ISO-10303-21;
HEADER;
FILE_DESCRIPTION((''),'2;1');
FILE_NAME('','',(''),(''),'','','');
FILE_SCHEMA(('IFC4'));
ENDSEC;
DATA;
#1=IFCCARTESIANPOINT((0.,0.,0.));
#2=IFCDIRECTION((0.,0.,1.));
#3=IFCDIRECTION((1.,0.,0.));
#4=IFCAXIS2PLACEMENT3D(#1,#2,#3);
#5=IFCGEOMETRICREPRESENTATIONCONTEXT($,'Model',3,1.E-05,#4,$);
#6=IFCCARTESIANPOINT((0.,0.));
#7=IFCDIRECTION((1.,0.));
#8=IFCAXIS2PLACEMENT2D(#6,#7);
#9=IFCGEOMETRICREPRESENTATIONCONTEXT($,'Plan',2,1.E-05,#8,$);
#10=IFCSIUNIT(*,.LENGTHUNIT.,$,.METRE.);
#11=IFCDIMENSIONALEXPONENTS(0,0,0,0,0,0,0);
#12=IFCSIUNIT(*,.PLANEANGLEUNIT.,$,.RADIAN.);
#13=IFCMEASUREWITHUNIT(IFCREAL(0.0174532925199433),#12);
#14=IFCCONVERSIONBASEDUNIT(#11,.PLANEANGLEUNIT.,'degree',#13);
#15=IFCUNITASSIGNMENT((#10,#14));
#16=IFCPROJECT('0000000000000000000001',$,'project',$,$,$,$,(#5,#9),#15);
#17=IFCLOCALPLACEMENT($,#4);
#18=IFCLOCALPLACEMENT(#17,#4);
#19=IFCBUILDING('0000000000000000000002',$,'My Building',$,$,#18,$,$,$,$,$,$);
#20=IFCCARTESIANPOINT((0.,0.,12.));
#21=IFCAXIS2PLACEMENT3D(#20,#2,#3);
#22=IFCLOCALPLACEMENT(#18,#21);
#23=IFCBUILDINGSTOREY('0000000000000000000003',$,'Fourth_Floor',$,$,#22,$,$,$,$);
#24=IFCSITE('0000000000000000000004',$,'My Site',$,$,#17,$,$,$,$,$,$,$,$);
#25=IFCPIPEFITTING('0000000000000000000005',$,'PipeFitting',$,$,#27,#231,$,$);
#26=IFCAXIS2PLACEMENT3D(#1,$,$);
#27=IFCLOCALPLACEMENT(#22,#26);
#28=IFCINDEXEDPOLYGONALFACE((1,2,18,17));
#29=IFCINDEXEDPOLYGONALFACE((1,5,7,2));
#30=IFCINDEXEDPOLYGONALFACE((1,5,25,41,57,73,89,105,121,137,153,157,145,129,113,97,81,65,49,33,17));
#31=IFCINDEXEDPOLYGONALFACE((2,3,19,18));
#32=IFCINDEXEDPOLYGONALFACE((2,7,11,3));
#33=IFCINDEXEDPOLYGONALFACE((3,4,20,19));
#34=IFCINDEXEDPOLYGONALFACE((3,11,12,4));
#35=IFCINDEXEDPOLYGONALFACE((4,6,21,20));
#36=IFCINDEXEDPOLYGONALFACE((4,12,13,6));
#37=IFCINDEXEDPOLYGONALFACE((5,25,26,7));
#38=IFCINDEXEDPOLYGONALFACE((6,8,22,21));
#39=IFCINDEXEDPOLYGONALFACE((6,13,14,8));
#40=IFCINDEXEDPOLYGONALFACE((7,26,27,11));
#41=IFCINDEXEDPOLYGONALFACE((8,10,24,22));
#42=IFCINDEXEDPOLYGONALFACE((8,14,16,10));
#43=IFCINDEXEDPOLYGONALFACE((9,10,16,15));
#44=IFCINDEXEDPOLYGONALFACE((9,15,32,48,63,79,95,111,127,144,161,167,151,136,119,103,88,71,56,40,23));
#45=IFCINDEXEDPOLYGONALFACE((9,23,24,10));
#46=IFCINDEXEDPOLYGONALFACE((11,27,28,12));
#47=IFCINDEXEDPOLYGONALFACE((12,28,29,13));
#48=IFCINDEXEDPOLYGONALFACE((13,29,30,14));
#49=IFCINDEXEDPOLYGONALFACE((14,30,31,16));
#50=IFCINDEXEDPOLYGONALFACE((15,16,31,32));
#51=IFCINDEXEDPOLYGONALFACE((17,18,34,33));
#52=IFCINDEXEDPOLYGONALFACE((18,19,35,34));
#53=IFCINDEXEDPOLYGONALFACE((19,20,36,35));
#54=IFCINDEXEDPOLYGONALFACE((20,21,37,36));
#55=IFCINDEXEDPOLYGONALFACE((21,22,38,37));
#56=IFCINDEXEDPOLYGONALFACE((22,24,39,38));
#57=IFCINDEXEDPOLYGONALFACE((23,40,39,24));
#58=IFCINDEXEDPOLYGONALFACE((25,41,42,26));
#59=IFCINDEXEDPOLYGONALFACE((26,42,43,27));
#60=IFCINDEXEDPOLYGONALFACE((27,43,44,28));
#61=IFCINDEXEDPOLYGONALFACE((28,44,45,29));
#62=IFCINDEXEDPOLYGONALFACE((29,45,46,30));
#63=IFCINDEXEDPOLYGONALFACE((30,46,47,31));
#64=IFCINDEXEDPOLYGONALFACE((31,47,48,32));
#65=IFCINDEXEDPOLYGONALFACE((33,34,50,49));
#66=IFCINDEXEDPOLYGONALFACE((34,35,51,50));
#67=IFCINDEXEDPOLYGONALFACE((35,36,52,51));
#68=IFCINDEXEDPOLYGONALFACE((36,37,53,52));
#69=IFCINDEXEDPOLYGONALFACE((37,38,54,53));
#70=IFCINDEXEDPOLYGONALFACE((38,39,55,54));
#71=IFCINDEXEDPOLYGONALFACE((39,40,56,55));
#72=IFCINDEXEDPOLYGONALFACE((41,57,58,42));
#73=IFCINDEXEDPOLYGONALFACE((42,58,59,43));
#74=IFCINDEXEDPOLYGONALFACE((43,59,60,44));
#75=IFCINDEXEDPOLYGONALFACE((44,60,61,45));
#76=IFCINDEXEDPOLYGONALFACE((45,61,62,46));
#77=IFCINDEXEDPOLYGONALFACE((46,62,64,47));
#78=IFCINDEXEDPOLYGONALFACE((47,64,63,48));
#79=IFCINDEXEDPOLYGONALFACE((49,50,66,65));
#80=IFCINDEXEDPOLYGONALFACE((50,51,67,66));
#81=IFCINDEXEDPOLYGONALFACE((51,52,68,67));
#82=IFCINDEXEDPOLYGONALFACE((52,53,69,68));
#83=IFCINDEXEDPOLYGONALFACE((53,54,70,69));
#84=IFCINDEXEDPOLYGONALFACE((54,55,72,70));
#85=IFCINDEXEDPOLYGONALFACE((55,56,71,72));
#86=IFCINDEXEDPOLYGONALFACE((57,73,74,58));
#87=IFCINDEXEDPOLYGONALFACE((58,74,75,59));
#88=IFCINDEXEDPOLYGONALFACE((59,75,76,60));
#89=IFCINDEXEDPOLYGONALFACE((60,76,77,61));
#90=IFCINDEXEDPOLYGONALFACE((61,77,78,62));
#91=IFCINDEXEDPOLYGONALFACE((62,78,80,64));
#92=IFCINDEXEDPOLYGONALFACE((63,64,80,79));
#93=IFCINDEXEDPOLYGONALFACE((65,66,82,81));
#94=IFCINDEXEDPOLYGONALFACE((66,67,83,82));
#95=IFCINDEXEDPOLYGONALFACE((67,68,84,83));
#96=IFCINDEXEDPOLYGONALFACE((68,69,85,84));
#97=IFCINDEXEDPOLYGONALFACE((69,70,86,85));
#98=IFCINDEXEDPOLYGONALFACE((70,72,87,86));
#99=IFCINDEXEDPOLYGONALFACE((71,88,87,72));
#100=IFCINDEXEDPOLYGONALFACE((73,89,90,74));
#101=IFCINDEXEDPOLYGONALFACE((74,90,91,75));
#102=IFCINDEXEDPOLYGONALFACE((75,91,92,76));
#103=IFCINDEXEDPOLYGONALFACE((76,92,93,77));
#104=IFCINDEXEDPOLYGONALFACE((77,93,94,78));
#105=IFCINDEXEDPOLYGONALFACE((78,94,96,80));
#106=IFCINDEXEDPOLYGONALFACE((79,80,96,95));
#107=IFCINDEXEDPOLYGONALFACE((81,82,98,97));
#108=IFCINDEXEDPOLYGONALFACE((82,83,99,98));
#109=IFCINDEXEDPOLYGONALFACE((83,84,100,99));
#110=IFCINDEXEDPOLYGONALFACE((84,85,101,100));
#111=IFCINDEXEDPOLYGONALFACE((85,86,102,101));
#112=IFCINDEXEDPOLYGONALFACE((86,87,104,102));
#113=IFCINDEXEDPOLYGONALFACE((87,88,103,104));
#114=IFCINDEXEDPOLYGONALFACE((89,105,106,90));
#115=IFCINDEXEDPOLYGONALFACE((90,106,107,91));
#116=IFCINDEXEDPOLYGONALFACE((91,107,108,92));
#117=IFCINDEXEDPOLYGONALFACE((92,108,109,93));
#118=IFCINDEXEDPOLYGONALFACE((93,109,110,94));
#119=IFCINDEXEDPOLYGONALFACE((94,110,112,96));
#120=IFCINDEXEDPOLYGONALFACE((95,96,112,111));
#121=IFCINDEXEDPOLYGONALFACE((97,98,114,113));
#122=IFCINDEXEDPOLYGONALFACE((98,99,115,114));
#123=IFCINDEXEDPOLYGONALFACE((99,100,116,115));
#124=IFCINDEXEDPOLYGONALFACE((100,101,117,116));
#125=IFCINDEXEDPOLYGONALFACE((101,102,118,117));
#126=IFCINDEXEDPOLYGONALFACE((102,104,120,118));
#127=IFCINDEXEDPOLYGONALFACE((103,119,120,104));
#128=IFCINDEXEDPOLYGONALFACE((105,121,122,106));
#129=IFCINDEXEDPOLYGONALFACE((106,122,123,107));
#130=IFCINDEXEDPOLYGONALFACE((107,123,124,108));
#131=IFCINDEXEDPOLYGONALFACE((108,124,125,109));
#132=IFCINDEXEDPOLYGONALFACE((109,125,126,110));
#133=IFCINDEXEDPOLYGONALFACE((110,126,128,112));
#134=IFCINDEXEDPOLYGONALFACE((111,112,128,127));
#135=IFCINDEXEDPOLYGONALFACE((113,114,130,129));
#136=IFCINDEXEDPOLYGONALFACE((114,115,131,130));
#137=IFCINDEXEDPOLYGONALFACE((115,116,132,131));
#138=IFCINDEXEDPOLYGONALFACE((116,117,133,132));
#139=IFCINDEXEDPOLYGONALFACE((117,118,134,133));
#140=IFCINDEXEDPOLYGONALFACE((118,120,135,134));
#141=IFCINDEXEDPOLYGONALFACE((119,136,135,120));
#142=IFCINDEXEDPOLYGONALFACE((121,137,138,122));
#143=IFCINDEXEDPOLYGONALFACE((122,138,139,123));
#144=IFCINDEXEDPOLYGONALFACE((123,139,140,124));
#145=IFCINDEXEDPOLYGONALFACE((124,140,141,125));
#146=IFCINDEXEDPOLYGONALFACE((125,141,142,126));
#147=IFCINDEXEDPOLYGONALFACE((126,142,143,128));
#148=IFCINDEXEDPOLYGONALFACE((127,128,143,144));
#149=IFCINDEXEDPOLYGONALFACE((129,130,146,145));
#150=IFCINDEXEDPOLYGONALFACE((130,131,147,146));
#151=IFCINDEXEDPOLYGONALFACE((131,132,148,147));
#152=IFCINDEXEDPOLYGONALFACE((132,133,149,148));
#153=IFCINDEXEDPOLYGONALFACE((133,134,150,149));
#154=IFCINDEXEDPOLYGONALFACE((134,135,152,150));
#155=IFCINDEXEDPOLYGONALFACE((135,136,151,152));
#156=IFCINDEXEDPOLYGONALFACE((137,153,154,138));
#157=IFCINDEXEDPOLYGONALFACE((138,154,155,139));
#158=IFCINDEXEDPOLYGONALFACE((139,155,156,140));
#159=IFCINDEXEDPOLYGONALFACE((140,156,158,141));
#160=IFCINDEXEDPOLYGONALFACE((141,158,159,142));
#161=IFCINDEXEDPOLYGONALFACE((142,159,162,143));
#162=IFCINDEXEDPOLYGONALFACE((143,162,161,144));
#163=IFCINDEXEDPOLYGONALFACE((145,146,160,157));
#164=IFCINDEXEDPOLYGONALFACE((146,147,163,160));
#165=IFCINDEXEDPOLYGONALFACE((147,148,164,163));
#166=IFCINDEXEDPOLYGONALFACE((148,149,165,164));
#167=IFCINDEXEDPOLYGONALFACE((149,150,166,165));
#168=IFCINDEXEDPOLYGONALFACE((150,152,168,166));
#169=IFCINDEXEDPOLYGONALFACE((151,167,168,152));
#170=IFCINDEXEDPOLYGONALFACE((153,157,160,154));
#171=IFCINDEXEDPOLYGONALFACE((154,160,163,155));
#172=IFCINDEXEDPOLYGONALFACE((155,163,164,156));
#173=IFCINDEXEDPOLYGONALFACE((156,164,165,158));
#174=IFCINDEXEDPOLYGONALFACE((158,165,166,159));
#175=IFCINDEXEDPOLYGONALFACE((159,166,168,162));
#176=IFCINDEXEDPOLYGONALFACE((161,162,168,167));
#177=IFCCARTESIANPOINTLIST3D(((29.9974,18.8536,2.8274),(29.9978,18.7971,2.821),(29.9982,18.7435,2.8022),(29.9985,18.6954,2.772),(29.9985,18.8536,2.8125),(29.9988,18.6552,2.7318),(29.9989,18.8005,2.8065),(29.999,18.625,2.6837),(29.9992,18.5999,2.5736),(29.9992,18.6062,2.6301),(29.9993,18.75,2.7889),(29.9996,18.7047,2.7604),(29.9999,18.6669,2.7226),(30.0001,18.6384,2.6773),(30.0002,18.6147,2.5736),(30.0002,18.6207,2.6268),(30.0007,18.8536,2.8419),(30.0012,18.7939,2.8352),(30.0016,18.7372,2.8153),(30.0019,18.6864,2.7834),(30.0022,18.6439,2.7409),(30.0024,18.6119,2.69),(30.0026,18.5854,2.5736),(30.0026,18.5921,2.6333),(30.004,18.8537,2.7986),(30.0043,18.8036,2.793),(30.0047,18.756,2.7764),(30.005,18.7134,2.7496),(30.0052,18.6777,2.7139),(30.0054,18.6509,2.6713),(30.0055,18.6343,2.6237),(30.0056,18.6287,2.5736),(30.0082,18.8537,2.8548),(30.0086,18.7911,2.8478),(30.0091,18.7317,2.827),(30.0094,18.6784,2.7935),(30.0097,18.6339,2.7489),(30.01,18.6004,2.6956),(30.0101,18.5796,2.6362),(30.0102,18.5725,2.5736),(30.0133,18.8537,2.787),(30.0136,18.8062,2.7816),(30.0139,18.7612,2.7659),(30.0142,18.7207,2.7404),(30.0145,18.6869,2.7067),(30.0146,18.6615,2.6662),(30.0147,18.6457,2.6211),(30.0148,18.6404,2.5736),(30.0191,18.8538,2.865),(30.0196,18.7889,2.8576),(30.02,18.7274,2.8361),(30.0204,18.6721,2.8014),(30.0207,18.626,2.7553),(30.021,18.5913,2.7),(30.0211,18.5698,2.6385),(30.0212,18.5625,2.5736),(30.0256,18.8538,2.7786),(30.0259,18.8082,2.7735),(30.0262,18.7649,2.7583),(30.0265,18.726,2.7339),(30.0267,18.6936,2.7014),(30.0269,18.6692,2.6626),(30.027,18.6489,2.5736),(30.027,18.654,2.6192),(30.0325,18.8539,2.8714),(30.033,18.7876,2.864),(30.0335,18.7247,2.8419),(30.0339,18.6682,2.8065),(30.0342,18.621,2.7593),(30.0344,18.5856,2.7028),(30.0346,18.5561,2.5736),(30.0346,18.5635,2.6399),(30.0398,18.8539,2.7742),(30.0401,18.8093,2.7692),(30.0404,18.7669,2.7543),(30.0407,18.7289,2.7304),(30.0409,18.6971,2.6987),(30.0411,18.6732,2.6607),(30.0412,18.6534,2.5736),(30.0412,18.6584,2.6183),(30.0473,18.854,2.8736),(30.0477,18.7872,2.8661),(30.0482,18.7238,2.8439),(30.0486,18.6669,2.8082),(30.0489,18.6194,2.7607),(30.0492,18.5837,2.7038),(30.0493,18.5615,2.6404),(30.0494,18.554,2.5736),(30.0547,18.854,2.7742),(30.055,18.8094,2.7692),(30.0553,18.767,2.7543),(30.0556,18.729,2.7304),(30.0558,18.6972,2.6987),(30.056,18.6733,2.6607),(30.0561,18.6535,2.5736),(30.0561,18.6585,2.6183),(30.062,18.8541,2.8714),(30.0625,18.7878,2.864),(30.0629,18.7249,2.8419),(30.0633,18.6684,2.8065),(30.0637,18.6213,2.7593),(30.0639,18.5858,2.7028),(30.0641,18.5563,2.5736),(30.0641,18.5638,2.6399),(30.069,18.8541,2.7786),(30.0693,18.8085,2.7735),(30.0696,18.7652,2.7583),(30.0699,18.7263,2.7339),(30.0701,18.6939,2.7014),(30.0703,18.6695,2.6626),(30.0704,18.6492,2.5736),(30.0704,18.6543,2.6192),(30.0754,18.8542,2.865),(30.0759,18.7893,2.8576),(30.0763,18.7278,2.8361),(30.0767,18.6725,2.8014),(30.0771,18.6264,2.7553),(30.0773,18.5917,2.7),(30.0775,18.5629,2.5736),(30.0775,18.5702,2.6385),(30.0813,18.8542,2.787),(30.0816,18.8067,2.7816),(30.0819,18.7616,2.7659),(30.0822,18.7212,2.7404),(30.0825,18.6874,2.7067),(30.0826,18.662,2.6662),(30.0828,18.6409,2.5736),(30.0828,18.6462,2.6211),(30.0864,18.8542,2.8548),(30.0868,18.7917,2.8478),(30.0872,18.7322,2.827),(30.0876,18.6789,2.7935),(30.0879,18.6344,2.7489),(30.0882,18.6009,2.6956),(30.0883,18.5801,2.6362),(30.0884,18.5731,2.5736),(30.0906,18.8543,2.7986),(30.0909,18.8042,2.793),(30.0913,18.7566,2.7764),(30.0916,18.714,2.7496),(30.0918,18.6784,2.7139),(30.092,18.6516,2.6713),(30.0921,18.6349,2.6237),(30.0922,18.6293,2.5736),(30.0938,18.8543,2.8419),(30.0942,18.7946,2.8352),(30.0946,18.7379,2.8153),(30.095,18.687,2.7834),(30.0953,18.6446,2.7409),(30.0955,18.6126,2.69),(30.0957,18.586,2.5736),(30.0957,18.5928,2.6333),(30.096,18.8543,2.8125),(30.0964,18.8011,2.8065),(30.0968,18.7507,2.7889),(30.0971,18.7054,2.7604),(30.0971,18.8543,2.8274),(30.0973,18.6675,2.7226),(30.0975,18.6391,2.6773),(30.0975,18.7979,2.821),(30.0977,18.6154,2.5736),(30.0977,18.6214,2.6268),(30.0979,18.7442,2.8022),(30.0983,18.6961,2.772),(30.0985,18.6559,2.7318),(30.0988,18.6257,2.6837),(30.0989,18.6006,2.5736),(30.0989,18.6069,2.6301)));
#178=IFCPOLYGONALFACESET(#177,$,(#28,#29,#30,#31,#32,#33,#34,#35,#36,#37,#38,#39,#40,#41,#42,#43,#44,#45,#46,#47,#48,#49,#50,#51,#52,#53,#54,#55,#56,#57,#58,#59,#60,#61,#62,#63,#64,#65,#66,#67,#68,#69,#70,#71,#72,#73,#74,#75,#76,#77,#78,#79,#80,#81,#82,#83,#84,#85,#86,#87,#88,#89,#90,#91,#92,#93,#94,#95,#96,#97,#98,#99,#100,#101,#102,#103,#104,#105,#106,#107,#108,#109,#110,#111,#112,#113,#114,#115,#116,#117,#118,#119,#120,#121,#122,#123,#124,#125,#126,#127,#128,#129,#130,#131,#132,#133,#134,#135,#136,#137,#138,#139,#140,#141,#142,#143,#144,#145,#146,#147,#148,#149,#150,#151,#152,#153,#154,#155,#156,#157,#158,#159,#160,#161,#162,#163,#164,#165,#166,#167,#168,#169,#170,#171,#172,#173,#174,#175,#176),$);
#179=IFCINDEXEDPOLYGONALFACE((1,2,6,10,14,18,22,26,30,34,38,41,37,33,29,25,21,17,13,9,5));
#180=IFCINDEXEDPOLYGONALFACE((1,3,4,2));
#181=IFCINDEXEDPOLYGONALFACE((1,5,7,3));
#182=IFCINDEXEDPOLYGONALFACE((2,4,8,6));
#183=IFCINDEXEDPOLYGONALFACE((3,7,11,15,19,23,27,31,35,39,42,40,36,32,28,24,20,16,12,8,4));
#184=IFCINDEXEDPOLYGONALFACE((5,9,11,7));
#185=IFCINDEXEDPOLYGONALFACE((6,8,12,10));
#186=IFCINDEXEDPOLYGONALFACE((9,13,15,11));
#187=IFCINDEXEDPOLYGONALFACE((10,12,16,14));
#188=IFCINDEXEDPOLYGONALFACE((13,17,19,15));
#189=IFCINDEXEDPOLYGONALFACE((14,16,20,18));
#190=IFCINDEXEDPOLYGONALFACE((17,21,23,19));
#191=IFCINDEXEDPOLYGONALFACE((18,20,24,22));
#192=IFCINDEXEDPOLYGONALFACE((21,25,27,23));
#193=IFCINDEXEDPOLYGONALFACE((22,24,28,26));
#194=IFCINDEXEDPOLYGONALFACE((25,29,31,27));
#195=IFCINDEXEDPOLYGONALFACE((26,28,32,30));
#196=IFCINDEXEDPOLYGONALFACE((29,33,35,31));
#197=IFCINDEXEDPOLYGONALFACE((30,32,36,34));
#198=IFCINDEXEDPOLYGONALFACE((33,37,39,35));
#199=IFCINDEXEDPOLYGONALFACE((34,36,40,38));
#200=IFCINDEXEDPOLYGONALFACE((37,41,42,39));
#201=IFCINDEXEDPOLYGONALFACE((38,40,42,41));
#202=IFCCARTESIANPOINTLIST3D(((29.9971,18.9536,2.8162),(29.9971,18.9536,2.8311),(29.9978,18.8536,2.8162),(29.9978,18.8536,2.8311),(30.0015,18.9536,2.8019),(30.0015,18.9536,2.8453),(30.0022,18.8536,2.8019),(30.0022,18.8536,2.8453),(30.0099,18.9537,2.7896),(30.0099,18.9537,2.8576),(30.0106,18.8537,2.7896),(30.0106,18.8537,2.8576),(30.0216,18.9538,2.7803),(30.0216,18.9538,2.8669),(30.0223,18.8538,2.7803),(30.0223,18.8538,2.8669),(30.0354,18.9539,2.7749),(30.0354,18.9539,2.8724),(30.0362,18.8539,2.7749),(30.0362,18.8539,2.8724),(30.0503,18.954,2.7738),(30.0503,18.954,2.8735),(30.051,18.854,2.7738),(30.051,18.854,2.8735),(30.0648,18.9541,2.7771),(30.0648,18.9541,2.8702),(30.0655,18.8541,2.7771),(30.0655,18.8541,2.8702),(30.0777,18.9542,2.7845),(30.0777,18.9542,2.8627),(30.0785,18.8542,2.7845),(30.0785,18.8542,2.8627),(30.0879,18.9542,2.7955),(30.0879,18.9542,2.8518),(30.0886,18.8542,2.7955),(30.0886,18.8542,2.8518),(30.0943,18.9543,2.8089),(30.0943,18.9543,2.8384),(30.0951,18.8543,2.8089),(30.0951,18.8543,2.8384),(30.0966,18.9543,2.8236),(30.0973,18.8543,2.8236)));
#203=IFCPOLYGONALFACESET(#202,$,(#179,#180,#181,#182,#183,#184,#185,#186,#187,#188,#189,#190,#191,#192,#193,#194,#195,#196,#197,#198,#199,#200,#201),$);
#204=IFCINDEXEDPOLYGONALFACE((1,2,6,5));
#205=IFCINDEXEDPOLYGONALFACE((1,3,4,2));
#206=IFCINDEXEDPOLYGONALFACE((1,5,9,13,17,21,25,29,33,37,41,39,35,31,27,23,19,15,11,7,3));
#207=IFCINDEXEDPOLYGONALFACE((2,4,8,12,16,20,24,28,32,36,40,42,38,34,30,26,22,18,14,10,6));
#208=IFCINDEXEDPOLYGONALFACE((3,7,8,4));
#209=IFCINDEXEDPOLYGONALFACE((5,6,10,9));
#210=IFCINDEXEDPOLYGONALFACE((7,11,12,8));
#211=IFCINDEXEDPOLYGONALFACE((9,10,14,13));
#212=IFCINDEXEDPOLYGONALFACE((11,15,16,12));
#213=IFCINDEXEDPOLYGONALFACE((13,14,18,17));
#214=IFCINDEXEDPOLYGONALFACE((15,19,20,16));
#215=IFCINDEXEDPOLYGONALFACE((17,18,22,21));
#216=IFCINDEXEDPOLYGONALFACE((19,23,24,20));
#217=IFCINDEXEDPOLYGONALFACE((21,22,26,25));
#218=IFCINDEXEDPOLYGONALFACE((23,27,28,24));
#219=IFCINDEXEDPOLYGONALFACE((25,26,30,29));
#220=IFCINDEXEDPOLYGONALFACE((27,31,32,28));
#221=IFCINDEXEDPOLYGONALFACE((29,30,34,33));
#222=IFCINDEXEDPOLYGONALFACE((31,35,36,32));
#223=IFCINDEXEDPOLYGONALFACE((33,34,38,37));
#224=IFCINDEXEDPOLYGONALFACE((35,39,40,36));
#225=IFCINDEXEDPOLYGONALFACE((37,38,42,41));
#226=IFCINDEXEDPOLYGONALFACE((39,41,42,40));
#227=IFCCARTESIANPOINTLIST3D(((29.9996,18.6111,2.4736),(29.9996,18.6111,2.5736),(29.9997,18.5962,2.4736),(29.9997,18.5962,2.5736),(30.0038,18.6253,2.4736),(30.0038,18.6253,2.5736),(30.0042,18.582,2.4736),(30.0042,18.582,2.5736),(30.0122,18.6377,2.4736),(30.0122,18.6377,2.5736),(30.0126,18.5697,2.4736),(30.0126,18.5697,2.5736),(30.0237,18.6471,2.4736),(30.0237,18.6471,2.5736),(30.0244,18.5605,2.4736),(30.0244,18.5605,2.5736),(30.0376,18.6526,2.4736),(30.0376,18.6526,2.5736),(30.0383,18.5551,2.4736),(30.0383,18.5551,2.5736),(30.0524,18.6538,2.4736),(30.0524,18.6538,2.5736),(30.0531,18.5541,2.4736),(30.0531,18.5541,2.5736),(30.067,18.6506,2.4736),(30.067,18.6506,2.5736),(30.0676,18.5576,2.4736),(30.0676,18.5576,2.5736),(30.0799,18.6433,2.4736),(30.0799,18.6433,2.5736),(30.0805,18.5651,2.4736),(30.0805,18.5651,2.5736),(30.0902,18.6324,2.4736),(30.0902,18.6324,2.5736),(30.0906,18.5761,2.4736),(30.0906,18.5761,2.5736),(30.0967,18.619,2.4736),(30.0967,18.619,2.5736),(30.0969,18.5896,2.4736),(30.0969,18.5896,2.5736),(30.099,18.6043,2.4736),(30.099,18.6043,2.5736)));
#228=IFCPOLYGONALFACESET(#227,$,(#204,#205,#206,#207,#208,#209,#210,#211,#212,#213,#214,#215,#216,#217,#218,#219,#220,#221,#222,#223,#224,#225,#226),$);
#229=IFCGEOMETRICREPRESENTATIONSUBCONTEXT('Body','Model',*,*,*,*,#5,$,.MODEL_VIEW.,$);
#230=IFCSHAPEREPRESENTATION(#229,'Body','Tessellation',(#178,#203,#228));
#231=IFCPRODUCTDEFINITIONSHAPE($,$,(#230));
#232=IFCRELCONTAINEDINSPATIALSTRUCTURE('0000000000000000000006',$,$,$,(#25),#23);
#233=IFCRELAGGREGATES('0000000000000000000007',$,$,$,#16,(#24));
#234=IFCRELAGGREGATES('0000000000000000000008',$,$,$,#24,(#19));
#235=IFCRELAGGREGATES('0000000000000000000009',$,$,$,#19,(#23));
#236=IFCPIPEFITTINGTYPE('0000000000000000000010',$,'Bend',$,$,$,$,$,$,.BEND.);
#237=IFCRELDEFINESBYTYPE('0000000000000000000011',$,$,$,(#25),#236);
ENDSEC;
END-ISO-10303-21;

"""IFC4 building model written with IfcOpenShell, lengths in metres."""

from ifc_helpers import new_model, entity, si_unit, converted_unit, frame, origin_with_axes, origin_2d_with_axis, place, context, subcontext, project, spatial, circle, extrude, source, transform, mapped, type_object, type_shapes, element, save


model = new_model("IFC4")

# Units and contexts
model_context = context("Model", 3, precision=1e-05, world=origin_with_axes())
plan_context = context("Plan", 2, precision=1e-05, world=origin_2d_with_axis())
body_context_1 = subcontext(model_context, "Body", "Model", "MODEL_VIEW")
ifc_project = project(units=[si_unit("LENGTHUNIT", "METRE"), converted_unit("PLANEANGLEUNIT", "degree", entity("IfcReal", 0.0174532925199433), si_unit("PLANEANGLEUNIT", "RADIAN"), dimensions=[0, 0, 0, 0, 0, 0, 0])], contexts=[model_context, plan_context])

# Site, building, storey
site_placement = place(None, origin_with_axes())
site = spatial("IfcSite", under=ifc_project, at=site_placement, Name="My Site")
building_placement = place(site_placement, origin_with_axes())
building = spatial("IfcBuilding", under=site, at=building_placement, Name="My Building")
storey_placement = place(building_placement, frame((0.0, 0.0, 12.0), z_axis=(0.0, 0.0, 1.0), x_axis=(1.0, 0.0, 0.0)))
storey = spatial("IfcBuildingStorey", under=building, at=storey_placement, Name="Fourth_Floor")

# Pipe fitting
pipe_fitting_type = type_object("IfcPipeFittingType", Name="Bend", PredefinedType="BEND")
shared_shape_1 = source(origin_with_axes(), body_context_1, "Body", "SolidModel", [
    entity("IfcSweptDiskSolid", entity("IfcIndexedPolyCurve", entity("IfcCartesianPointList3D", [[0.0, 0.0, -0.1], [0.0, 0.0732, -0.2768], [0.0, 0.25, -0.35]]), [entity("IfcArcIndex", [1, 2, 3])]), 0.05),
    extrude(circle(Radius=0.05), origin_with_axes(), (0.0, 0.0, -1.0), 0.1),
    extrude(circle(Radius=0.05), frame((0.0, 0.25, -0.35), z_axis=(0.0, 1.0, 0.0), x_axis=(1.0, 0.0, 0.0)), (0.0, 0.0, 1.0), 0.1),
])
type_shapes(pipe_fitting_type, [shared_shape_1])
for number, where, z_axis, x_axis, name in (
    (1, (30.0466, 18.954, 2.8236), (-0.007084, 0.999975, 0.0), (0.999975, 0.007084, 0.0), "PipeFitting"),
):
    element("IfcPipeFitting", number, at=place(storey_placement, frame(where, z_axis=z_axis, x_axis=x_axis)), inside=storey, type_object=pipe_fitting_type, Name=name, context=body_context_1, shape_type="MappedRepresentation", body=[
        mapped(shared_shape_1, transform((0.0, 0.0, 0.0), x_axis=(1.0, 0.0, 0.0), y_axis=(0.0, 1.0, 0.0), z_axis=(0.0, 0.0, 1.0), scale=1.0)),
    ])

save(model, "model.ifc")
